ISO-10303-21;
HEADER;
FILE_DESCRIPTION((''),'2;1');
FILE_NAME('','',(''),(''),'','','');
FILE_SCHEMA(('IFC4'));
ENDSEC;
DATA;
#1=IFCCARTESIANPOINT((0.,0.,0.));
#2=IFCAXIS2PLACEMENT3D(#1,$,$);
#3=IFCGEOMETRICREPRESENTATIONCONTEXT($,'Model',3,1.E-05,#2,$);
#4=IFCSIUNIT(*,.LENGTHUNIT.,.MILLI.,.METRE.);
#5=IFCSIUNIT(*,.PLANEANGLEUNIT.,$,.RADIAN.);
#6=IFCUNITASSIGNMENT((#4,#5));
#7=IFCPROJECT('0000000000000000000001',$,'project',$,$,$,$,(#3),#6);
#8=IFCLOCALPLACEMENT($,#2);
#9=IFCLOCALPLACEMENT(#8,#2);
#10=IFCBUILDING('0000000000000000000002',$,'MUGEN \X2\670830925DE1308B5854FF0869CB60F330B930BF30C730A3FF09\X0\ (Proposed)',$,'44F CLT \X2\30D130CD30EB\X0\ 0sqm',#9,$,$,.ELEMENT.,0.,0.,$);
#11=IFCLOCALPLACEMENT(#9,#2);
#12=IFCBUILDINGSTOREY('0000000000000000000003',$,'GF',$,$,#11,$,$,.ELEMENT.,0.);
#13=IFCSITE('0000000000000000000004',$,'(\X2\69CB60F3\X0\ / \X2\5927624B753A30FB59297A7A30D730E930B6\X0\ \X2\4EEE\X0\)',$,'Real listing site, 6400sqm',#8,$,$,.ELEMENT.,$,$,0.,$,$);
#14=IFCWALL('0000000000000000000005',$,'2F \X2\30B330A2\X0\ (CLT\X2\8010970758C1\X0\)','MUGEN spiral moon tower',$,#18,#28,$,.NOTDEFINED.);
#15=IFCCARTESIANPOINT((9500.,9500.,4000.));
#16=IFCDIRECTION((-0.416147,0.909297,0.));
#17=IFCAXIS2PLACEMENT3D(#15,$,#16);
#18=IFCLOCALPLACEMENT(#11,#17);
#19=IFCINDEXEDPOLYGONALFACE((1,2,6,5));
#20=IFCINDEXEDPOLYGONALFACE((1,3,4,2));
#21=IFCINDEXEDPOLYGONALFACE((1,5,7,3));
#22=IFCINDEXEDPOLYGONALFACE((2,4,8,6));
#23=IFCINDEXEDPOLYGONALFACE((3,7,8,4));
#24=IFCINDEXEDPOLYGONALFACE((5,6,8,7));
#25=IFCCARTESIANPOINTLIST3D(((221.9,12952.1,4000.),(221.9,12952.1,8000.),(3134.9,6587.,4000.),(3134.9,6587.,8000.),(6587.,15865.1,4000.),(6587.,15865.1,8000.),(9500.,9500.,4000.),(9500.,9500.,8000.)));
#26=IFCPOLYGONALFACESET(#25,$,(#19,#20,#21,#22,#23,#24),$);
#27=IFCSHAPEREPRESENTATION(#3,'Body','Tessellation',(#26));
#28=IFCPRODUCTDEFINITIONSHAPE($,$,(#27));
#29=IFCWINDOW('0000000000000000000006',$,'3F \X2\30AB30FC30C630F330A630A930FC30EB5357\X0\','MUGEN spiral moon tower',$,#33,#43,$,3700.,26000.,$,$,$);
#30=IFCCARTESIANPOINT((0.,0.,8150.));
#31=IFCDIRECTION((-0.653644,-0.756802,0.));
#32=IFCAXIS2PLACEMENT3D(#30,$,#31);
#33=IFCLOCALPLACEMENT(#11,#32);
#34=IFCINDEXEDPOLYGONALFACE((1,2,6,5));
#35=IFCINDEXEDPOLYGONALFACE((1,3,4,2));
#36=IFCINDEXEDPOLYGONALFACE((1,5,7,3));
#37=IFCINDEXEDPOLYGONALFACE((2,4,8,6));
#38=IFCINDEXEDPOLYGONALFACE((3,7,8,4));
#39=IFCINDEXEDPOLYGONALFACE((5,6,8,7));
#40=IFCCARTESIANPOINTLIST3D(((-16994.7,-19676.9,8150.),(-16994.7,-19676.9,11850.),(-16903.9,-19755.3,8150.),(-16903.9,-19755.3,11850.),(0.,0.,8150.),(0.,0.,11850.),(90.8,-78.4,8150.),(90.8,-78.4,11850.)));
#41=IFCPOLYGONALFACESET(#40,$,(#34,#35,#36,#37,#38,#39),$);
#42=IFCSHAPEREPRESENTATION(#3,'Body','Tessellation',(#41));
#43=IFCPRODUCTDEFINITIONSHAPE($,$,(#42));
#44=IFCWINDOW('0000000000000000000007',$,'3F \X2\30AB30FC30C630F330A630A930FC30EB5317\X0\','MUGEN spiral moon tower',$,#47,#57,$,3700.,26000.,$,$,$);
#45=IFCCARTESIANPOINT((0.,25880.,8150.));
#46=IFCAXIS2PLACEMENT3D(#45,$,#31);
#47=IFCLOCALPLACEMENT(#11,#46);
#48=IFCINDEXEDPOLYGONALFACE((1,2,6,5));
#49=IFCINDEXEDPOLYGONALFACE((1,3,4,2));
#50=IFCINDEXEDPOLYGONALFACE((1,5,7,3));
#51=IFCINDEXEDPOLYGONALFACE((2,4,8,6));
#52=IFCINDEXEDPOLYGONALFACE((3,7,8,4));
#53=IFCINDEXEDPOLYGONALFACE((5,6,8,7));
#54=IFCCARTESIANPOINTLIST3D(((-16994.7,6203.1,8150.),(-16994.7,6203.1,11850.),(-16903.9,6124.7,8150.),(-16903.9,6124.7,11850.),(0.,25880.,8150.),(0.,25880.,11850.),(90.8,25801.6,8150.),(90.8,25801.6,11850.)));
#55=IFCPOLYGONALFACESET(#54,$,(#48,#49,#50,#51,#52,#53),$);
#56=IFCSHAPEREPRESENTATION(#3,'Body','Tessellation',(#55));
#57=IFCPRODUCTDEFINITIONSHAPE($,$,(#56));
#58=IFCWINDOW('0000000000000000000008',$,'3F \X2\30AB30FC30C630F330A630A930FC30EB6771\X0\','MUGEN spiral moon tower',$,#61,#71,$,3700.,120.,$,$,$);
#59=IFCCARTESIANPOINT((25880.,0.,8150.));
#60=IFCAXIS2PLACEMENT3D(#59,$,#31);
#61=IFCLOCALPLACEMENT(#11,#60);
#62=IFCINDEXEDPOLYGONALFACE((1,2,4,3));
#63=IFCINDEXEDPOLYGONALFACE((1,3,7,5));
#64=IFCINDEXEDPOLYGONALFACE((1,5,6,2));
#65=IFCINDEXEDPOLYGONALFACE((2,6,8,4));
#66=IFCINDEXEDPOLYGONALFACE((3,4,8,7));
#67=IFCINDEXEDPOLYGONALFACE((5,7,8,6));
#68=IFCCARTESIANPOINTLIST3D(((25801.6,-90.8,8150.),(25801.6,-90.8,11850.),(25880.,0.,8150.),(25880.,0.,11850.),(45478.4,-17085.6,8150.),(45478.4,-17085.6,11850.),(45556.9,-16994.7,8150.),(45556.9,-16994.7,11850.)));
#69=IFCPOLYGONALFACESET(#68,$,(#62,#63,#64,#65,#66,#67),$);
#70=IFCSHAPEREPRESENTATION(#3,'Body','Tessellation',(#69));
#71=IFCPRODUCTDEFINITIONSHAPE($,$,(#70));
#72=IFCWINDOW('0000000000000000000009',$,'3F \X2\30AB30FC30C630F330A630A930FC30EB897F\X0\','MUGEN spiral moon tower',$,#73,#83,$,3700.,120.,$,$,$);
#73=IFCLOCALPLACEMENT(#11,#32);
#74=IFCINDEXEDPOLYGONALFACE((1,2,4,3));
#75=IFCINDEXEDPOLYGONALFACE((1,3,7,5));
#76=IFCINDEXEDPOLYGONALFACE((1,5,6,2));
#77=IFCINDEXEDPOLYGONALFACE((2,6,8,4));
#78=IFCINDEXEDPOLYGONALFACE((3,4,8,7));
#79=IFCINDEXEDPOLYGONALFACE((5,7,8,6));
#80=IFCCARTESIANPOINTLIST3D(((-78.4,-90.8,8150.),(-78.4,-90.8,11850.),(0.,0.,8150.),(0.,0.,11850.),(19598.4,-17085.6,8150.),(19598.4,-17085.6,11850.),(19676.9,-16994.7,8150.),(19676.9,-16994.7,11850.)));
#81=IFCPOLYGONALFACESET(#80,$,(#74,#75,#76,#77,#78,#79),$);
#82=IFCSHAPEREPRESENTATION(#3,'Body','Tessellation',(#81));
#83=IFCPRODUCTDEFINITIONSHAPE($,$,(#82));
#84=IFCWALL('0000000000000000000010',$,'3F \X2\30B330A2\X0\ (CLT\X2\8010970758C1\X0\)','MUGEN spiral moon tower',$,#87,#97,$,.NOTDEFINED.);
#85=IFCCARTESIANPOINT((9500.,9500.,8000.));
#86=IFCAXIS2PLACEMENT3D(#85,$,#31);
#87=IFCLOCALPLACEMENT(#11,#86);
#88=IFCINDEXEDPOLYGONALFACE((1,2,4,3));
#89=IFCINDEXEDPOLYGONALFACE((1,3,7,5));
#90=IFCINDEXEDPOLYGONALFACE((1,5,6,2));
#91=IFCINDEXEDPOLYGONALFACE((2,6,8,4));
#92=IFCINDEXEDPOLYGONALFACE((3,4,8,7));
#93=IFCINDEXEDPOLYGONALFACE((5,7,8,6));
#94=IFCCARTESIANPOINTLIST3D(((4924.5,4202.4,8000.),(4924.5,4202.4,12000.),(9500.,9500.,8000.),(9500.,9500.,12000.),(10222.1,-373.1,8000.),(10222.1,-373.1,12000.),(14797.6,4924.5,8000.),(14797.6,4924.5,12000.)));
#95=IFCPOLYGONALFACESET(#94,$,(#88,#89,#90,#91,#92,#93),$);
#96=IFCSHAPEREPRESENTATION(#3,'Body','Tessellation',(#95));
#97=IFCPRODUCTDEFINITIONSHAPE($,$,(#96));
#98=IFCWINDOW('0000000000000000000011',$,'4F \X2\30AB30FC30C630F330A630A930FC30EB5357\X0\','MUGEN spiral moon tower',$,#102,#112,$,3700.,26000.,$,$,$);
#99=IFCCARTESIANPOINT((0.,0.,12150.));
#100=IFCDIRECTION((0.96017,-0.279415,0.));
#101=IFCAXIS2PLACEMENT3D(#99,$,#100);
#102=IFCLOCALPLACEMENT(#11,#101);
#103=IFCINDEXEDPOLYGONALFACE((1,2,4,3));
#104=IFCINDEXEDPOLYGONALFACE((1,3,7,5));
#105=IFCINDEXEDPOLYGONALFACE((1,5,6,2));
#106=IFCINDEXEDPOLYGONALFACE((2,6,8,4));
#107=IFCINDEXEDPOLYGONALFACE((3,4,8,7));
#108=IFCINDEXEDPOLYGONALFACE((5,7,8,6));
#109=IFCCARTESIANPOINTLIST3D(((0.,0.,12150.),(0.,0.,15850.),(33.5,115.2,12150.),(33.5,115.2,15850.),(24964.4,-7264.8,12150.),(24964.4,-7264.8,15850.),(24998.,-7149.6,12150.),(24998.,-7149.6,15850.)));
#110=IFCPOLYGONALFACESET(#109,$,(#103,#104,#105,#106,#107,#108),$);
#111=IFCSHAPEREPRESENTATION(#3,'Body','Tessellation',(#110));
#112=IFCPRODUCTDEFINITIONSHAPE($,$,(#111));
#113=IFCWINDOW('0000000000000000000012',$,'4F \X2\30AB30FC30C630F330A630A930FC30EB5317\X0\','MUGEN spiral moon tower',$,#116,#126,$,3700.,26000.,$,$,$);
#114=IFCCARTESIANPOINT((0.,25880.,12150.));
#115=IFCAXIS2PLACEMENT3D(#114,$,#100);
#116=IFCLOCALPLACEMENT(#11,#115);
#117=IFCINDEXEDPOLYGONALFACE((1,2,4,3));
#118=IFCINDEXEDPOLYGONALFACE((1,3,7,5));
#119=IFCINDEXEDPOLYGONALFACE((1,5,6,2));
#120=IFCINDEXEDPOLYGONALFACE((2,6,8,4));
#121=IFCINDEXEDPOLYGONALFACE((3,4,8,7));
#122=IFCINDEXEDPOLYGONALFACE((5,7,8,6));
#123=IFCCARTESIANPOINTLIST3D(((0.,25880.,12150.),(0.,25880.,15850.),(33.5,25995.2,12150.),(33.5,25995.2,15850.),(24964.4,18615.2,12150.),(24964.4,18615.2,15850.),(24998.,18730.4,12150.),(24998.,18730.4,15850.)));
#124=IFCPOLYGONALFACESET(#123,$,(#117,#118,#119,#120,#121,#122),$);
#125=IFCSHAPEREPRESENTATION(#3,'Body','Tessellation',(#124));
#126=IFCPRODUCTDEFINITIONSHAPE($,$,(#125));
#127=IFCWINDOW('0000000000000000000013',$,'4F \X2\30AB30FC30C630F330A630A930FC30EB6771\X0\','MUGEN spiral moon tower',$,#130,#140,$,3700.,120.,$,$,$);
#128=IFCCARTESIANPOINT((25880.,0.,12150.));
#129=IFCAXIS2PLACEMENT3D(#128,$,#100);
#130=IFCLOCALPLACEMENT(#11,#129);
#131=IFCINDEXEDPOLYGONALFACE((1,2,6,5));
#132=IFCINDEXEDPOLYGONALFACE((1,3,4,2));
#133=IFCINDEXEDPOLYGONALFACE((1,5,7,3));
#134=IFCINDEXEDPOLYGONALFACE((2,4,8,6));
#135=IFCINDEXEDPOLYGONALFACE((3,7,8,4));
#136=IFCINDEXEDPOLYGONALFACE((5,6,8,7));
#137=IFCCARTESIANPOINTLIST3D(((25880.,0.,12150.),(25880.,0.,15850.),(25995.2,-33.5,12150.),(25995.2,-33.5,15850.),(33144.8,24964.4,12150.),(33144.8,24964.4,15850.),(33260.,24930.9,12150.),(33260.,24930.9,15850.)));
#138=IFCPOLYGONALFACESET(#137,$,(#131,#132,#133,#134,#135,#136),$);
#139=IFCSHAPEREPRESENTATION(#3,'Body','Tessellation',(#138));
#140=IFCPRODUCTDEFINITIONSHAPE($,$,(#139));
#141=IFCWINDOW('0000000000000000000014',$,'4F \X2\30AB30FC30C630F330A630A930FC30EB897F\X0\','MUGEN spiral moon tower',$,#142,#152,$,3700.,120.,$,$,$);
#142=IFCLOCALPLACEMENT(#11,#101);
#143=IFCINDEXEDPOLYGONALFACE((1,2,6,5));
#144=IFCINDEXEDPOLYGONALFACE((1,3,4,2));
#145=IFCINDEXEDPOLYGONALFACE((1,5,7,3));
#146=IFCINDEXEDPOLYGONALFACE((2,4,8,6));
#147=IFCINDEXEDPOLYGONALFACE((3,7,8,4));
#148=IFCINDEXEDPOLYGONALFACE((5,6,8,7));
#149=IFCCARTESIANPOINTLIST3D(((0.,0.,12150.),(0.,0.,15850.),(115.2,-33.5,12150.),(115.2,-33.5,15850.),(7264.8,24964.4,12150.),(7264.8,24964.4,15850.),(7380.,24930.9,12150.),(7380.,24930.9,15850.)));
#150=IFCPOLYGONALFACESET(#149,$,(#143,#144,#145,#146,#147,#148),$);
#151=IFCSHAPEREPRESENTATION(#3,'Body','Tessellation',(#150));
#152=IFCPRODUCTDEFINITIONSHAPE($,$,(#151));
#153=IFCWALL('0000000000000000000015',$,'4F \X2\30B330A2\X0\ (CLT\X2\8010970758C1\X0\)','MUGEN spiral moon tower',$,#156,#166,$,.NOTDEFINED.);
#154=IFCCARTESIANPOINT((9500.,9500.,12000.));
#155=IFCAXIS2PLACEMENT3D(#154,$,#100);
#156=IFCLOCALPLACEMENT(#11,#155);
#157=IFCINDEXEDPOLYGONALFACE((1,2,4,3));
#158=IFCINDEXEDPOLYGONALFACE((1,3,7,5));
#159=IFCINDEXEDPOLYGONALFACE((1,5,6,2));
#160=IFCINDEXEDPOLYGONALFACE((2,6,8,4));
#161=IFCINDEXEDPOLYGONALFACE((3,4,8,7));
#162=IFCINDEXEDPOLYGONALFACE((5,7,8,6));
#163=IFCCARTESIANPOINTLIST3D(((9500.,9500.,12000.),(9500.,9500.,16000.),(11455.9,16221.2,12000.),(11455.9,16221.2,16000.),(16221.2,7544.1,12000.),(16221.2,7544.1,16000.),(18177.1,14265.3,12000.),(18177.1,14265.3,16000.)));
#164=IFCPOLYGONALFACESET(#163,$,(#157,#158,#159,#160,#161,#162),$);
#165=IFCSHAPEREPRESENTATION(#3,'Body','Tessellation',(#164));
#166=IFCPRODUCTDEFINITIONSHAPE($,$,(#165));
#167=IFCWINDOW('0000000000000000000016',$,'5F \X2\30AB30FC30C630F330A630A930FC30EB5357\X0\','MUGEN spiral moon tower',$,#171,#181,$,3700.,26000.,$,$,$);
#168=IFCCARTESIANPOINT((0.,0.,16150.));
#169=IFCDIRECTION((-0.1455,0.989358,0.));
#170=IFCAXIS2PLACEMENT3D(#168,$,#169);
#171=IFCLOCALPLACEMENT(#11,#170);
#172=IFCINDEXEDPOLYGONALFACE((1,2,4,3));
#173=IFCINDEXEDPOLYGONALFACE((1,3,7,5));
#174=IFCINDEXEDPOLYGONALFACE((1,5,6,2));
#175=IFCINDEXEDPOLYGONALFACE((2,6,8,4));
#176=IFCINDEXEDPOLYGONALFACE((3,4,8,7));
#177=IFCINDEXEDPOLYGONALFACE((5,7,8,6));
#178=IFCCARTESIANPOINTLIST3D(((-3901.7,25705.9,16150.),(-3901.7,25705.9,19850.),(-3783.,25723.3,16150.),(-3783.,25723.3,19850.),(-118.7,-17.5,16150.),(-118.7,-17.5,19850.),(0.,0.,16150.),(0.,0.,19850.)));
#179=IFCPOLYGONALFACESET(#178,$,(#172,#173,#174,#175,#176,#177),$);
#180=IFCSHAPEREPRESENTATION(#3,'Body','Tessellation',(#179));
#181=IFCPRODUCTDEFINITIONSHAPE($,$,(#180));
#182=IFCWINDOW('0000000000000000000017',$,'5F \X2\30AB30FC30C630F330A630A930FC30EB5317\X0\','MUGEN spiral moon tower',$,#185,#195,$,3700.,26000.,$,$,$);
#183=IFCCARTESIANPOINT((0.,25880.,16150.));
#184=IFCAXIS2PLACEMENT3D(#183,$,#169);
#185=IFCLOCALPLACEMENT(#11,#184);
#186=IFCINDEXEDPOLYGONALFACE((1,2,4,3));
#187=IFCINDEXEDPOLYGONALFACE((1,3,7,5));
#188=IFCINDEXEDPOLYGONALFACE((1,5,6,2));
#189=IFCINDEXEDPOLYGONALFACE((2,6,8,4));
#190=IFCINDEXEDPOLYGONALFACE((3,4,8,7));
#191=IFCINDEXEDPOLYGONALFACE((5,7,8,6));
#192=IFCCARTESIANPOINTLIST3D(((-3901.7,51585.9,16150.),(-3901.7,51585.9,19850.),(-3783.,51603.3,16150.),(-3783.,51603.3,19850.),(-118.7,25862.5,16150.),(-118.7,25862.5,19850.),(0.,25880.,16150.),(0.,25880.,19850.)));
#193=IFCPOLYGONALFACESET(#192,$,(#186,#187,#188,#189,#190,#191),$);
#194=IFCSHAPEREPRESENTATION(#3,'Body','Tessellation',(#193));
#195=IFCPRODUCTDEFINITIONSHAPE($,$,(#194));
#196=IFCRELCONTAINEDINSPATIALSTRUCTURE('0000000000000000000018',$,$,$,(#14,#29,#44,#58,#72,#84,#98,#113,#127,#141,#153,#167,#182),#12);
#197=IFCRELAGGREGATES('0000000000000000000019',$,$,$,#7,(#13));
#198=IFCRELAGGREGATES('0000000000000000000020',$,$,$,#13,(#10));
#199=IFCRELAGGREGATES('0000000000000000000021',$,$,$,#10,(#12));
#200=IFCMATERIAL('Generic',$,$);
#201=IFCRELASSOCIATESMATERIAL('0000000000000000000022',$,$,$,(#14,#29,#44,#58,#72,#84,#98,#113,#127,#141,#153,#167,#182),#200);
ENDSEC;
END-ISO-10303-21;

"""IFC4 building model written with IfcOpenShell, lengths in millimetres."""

from ifc_helpers import new_model, si_unit, frame, frame_2d, origin, place, context, project, spatial, rectangle, extrude, material, element, save


model = new_model("IFC4")

# Units and contexts
model_context = context("Model", 3, precision=1e-05, world=origin())
ifc_project = project(units=[si_unit("LENGTHUNIT", "METRE", prefix="MILLI"), si_unit("PLANEANGLEUNIT", "RADIAN")], contexts=[model_context])

# Site, building, storey
site_placement = place(None, origin())
site = spatial("IfcSite", under=ifc_project, at=site_placement, Name="(構想 / 大手町・天空プラザ 仮)", ObjectType="Real listing site, 6400sqm", CompositionType="ELEMENT", RefElevation=0.0)
building_placement = place(site_placement, origin())
building = spatial("IfcBuilding", under=site, at=building_placement, Name="MUGEN 月を巡る塔（構想スタディ） (Proposed)", ObjectType="44F CLT パネル 0sqm", CompositionType="ELEMENT", ElevationOfRefHeight=0.0, ElevationOfTerrain=0.0)
storey_placement = place(building_placement, origin())
storey = spatial("IfcBuildingStorey", under=building, at=storey_placement, Name="GF", CompositionType="ELEMENT", Elevation=0.0)

# Shared definitions
ifc_material = material(Name="Generic")

# Wall
wall_1_placement = place(storey_placement, frame((9500.0, 9500.0, 4000.0), x_axis=(-0.416147, 0.909297, 0.0)))
element("IfcWall", 1, at=wall_1_placement, inside=storey, material=ifc_material, Name="2F コア (CLT耐震壁)", Description="MUGEN spiral moon tower", PredefinedType="NOTDEFINED", context=model_context, shape_type="SweptSolid", body=[
    extrude(rectangle(XDim=7000.0, YDim=7000.0, at=frame_2d((3500.0, 3500.0))), frame((9500.0, 9500.0, 4000.0), x_axis=(-0.416147, 0.909297, 0.0)), (0.0, 0.0, 1.0), 4000.0),
])

# Windows
window_1_placement = place(storey_placement, frame((0.0, 0.0, 8150.0), x_axis=(-0.653644, -0.756802, 0.0)))
element("IfcWindow", 2, at=window_1_placement, inside=storey, material=ifc_material, Name="3F カーテンウォール南", Description="MUGEN spiral moon tower", OverallHeight=3700.0, OverallWidth=26000.0, context=model_context, shape_type="SweptSolid", body=[
    extrude(rectangle(XDim=26000.0, YDim=120.0, at=frame_2d((13000.0, 60.0))), frame((0.0, 0.0, 8150.0), x_axis=(-0.653644, -0.756802, 0.0)), (0.0, 0.0, 1.0), 3700.0),
])
window_2_placement = place(storey_placement, frame((0.0, 25880.0, 8150.0), x_axis=(-0.653644, -0.756802, 0.0)))
element("IfcWindow", 3, at=window_2_placement, inside=storey, material=ifc_material, Name="3F カーテンウォール北", Description="MUGEN spiral moon tower", OverallHeight=3700.0, OverallWidth=26000.0, context=model_context, shape_type="SweptSolid", body=[
    extrude(rectangle(XDim=26000.0, YDim=120.0, at=frame_2d((13000.0, 60.0))), frame((0.0, 25880.0, 8150.0), x_axis=(-0.653644, -0.756802, 0.0)), (0.0, 0.0, 1.0), 3700.0),
])
window_3_placement = place(storey_placement, frame((25880.0, 0.0, 8150.0), x_axis=(-0.653644, -0.756802, 0.0)))
element("IfcWindow", 4, at=window_3_placement, inside=storey, material=ifc_material, Name="3F カーテンウォール東", Description="MUGEN spiral moon tower", OverallHeight=3700.0, OverallWidth=120.0, context=model_context, shape_type="SweptSolid", body=[
    extrude(rectangle(XDim=120.0, YDim=26000.0, at=frame_2d((60.0, 13000.0))), frame((25880.0, 0.0, 8150.0), x_axis=(-0.653644, -0.756802, 0.0)), (0.0, 0.0, 1.0), 3700.0),
])
window_4_placement = place(storey_placement, frame((0.0, 0.0, 8150.0), x_axis=(-0.653644, -0.756802, 0.0)))
element("IfcWindow", 5, at=window_4_placement, inside=storey, material=ifc_material, Name="3F カーテンウォール西", Description="MUGEN spiral moon tower", OverallHeight=3700.0, OverallWidth=120.0, context=model_context, shape_type="SweptSolid", body=[
    extrude(rectangle(XDim=120.0, YDim=26000.0, at=frame_2d((60.0, 13000.0))), frame((0.0, 0.0, 8150.0), x_axis=(-0.653644, -0.756802, 0.0)), (0.0, 0.0, 1.0), 3700.0),
])

# Wall
wall_2_placement = place(storey_placement, frame((9500.0, 9500.0, 8000.0), x_axis=(-0.653644, -0.756802, 0.0)))
element("IfcWall", 6, at=wall_2_placement, inside=storey, material=ifc_material, Name="3F コア (CLT耐震壁)", Description="MUGEN spiral moon tower", PredefinedType="NOTDEFINED", context=model_context, shape_type="SweptSolid", body=[
    extrude(rectangle(XDim=7000.0, YDim=7000.0, at=frame_2d((3500.0, 3500.0))), frame((9500.0, 9500.0, 8000.0), x_axis=(-0.653644, -0.756802, 0.0)), (0.0, 0.0, 1.0), 4000.0),
])

# Windows
window_5_placement = place(storey_placement, frame((0.0, 0.0, 12150.0), x_axis=(0.96017, -0.279415, 0.0)))
element("IfcWindow", 7, at=window_5_placement, inside=storey, material=ifc_material, Name="4F カーテンウォール南", Description="MUGEN spiral moon tower", OverallHeight=3700.0, OverallWidth=26000.0, context=model_context, shape_type="SweptSolid", body=[
    extrude(rectangle(XDim=26000.0, YDim=120.0, at=frame_2d((13000.0, 60.0))), frame((0.0, 0.0, 12150.0), x_axis=(0.96017, -0.279415, 0.0)), (0.0, 0.0, 1.0), 3700.0),
])
window_6_placement = place(storey_placement, frame((0.0, 25880.0, 12150.0), x_axis=(0.96017, -0.279415, 0.0)))
element("IfcWindow", 8, at=window_6_placement, inside=storey, material=ifc_material, Name="4F カーテンウォール北", Description="MUGEN spiral moon tower", OverallHeight=3700.0, OverallWidth=26000.0, context=model_context, shape_type="SweptSolid", body=[
    extrude(rectangle(XDim=26000.0, YDim=120.0, at=frame_2d((13000.0, 60.0))), frame((0.0, 25880.0, 12150.0), x_axis=(0.96017, -0.279415, 0.0)), (0.0, 0.0, 1.0), 3700.0),
])
window_7_placement = place(storey_placement, frame((25880.0, 0.0, 12150.0), x_axis=(0.96017, -0.279415, 0.0)))
element("IfcWindow", 9, at=window_7_placement, inside=storey, material=ifc_material, Name="4F カーテンウォール東", Description="MUGEN spiral moon tower", OverallHeight=3700.0, OverallWidth=120.0, context=model_context, shape_type="SweptSolid", body=[
    extrude(rectangle(XDim=120.0, YDim=26000.0, at=frame_2d((60.0, 13000.0))), frame((25880.0, 0.0, 12150.0), x_axis=(0.96017, -0.279415, 0.0)), (0.0, 0.0, 1.0), 3700.0),
])
window_8_placement = place(storey_placement, frame((0.0, 0.0, 12150.0), x_axis=(0.96017, -0.279415, 0.0)))
element("IfcWindow", 10, at=window_8_placement, inside=storey, material=ifc_material, Name="4F カーテンウォール西", Description="MUGEN spiral moon tower", OverallHeight=3700.0, OverallWidth=120.0, context=model_context, shape_type="SweptSolid", body=[
    extrude(rectangle(XDim=120.0, YDim=26000.0, at=frame_2d((60.0, 13000.0))), frame((0.0, 0.0, 12150.0), x_axis=(0.96017, -0.279415, 0.0)), (0.0, 0.0, 1.0), 3700.0),
])

# Wall
wall_3_placement = place(storey_placement, frame((9500.0, 9500.0, 12000.0), x_axis=(0.96017, -0.279415, 0.0)))
element("IfcWall", 11, at=wall_3_placement, inside=storey, material=ifc_material, Name="4F コア (CLT耐震壁)", Description="MUGEN spiral moon tower", PredefinedType="NOTDEFINED", context=model_context, shape_type="SweptSolid", body=[
    extrude(rectangle(XDim=7000.0, YDim=7000.0, at=frame_2d((3500.0, 3500.0))), frame((9500.0, 9500.0, 12000.0), x_axis=(0.96017, -0.279415, 0.0)), (0.0, 0.0, 1.0), 4000.0),
])

# Windows
window_9_placement = place(storey_placement, frame((0.0, 0.0, 16150.0), x_axis=(-0.1455, 0.989358, 0.0)))
element("IfcWindow", 12, at=window_9_placement, inside=storey, material=ifc_material, Name="5F カーテンウォール南", Description="MUGEN spiral moon tower", OverallHeight=3700.0, OverallWidth=26000.0, context=model_context, shape_type="SweptSolid", body=[
    extrude(rectangle(XDim=26000.0, YDim=120.0, at=frame_2d((13000.0, 60.0))), frame((0.0, 0.0, 16150.0), x_axis=(-0.1455, 0.989358, 0.0)), (0.0, 0.0, 1.0), 3700.0),
])
window_10_placement = place(storey_placement, frame((0.0, 25880.0, 16150.0), x_axis=(-0.1455, 0.989358, 0.0)))
element("IfcWindow", 13, at=window_10_placement, inside=storey, material=ifc_material, Name="5F カーテンウォール北", Description="MUGEN spiral moon tower", OverallHeight=3700.0, OverallWidth=26000.0, context=model_context, shape_type="SweptSolid", body=[
    extrude(rectangle(XDim=26000.0, YDim=120.0, at=frame_2d((13000.0, 60.0))), frame((0.0, 25880.0, 16150.0), x_axis=(-0.1455, 0.989358, 0.0)), (0.0, 0.0, 1.0), 3700.0),
])

save(model, "model.ifc")
